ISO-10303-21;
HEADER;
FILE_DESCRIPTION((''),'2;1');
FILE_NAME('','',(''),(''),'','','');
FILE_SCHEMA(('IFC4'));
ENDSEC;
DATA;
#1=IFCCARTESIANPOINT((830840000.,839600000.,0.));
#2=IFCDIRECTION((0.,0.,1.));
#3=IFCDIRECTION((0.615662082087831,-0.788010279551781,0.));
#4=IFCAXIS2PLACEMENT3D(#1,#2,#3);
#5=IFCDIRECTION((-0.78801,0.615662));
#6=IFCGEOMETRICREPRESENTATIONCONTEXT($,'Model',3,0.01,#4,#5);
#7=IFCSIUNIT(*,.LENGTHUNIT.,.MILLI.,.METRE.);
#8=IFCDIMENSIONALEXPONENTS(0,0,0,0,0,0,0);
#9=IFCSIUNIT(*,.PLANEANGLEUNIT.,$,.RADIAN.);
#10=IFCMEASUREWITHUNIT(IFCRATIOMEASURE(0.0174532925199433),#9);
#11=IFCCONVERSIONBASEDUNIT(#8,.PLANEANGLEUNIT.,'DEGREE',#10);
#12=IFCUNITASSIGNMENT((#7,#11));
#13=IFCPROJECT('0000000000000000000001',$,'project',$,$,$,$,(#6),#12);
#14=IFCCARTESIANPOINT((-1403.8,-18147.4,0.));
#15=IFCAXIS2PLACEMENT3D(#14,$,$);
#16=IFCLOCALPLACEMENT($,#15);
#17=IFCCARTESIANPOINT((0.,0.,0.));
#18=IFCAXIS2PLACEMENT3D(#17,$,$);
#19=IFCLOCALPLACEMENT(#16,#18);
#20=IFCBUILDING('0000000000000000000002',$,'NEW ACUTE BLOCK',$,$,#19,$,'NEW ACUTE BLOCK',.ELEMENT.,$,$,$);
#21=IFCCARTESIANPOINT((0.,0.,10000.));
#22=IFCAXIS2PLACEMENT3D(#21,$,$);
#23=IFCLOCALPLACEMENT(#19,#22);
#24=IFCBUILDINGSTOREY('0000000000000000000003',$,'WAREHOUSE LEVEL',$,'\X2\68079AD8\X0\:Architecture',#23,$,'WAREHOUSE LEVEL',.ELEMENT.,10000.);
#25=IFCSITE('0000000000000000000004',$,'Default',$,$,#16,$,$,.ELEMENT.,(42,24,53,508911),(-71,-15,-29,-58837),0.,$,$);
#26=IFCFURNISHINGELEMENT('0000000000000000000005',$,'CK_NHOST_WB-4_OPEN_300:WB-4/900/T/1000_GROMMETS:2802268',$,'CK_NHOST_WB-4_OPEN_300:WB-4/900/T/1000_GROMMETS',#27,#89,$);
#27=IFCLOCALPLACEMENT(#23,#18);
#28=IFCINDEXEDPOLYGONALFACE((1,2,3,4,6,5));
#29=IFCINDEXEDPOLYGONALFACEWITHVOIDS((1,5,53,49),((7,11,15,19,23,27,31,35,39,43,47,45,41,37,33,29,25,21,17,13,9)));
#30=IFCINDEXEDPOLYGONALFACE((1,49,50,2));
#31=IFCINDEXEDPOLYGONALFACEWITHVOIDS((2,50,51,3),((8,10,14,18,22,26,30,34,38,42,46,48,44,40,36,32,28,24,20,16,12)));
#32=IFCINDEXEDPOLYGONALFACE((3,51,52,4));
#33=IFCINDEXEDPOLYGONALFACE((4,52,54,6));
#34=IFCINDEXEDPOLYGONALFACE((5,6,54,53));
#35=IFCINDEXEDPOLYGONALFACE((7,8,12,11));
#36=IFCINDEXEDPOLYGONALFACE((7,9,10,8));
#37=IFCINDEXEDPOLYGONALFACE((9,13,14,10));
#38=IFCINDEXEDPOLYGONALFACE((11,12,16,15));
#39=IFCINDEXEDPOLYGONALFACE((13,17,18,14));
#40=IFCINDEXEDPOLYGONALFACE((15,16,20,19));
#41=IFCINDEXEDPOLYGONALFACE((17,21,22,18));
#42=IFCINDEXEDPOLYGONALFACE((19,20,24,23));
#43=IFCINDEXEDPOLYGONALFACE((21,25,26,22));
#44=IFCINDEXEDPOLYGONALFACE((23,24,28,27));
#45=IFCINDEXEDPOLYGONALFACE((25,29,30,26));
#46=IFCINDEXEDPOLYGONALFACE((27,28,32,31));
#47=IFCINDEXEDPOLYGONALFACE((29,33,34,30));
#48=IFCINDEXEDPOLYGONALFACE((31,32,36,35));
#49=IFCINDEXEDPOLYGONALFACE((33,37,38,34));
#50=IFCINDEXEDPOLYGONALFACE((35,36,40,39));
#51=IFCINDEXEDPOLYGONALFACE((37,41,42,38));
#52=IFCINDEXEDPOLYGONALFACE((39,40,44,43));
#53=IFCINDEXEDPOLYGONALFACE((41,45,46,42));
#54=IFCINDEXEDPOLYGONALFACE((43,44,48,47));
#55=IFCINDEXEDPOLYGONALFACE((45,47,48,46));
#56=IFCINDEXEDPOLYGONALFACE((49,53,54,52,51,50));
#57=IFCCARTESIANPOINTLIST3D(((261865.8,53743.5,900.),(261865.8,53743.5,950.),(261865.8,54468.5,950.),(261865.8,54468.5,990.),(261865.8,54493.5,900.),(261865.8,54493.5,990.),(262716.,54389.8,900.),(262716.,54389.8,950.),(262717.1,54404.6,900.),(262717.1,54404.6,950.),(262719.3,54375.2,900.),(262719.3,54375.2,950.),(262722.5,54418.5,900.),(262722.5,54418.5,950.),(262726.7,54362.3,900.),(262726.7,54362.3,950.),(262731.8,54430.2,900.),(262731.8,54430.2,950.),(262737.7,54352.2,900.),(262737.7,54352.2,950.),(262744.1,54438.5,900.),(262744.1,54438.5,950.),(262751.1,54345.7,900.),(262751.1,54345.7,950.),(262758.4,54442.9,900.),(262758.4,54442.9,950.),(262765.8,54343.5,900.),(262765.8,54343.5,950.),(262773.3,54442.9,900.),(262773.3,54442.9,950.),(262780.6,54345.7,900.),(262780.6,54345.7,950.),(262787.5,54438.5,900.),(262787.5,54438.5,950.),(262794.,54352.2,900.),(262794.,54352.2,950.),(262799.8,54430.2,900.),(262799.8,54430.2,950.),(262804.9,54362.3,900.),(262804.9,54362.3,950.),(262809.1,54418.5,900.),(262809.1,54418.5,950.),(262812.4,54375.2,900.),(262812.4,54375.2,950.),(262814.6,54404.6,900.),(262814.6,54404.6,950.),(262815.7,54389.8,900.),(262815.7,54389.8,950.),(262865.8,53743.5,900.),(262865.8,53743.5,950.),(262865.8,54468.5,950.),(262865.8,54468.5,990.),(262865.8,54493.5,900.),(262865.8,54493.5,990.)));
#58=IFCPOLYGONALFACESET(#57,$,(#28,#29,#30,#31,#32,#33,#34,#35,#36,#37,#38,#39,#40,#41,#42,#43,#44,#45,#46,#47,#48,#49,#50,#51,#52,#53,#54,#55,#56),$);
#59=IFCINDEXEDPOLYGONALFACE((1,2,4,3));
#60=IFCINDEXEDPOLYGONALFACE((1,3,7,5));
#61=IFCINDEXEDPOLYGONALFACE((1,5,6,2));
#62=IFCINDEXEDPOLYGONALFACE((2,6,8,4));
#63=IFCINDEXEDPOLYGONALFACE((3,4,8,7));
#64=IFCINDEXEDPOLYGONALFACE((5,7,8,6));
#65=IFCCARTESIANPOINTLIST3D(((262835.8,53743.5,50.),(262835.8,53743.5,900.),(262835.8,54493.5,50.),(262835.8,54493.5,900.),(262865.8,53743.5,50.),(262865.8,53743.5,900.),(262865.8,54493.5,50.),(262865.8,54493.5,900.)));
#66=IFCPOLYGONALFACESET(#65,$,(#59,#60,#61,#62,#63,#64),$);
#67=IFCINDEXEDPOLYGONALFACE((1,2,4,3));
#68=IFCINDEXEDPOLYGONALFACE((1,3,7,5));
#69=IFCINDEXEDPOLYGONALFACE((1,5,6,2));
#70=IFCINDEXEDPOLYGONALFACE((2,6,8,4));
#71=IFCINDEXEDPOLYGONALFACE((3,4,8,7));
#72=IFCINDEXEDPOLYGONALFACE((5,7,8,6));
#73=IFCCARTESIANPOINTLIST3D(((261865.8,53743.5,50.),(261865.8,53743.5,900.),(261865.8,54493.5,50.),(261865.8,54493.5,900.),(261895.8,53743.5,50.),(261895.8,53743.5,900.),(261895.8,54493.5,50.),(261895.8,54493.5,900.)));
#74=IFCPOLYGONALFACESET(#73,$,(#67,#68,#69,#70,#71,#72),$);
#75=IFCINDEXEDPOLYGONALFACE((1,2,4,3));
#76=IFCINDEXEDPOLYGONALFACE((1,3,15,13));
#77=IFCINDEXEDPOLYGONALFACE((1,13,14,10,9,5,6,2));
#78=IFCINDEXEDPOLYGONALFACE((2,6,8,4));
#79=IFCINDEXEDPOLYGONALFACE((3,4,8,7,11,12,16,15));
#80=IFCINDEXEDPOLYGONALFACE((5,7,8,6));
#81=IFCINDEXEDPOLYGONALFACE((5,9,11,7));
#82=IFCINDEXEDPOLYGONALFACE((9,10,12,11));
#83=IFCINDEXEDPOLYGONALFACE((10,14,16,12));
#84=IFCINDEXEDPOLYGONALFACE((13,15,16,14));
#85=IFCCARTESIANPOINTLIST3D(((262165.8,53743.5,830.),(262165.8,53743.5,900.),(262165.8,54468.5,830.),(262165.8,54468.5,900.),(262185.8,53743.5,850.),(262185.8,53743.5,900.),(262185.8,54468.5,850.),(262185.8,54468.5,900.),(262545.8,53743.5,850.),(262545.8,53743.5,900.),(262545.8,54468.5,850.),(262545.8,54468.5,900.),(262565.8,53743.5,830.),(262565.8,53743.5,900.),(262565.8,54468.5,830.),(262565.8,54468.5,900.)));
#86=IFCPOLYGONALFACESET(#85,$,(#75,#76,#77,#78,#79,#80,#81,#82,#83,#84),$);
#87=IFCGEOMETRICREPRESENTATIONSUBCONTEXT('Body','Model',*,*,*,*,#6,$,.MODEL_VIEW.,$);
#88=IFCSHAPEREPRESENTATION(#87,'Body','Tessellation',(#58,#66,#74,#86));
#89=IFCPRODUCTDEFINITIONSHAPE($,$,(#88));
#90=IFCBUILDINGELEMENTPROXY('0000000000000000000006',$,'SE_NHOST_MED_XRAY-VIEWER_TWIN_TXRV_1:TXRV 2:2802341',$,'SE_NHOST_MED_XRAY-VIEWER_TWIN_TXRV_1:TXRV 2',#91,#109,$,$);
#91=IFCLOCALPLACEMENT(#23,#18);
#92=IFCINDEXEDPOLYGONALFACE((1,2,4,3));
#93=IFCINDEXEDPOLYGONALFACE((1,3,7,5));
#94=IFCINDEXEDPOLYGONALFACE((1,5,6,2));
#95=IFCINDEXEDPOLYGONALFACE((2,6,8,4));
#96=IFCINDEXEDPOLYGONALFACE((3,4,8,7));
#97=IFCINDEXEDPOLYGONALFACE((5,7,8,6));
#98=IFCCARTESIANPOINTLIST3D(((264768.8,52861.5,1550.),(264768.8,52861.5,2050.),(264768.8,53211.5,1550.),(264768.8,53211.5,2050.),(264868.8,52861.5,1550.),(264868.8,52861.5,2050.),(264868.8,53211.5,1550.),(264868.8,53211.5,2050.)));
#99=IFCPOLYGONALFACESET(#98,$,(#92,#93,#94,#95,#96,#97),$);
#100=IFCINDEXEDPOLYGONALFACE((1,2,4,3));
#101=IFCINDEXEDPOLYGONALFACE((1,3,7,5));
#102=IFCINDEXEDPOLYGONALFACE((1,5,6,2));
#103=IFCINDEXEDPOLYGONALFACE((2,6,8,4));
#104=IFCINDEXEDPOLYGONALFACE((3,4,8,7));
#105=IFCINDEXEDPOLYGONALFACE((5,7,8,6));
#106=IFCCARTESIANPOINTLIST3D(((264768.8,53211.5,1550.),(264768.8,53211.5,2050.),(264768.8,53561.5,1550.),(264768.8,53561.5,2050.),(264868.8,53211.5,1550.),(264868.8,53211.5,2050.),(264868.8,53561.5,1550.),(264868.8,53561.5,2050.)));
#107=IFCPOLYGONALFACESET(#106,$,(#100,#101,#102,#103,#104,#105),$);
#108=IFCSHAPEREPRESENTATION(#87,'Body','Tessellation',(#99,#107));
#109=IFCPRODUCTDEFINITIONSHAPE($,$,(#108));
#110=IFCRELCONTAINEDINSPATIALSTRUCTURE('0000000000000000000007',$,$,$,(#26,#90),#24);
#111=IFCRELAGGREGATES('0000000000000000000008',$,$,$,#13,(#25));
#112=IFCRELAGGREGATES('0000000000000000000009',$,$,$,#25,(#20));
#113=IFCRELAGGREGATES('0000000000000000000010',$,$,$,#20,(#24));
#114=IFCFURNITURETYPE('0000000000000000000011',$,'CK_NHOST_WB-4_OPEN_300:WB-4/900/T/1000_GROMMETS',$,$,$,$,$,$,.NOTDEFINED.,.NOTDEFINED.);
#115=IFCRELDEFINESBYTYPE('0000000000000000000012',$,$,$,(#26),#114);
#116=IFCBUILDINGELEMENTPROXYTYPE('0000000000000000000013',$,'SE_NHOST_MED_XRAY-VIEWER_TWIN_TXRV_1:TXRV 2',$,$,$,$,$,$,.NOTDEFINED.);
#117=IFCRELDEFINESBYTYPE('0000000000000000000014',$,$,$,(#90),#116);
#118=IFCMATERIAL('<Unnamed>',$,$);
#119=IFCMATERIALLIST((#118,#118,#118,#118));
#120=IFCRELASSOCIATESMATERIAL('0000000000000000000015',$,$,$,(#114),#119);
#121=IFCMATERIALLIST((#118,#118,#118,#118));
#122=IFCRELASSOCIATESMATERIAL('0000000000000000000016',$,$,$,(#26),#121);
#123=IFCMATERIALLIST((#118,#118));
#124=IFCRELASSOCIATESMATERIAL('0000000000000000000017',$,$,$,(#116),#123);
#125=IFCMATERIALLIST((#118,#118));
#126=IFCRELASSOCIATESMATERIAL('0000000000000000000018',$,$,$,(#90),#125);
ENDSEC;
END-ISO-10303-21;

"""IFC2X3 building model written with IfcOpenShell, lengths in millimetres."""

from ifc_helpers import new_model, entity, si_unit, converted_unit, direction, frame, frame_2d, origin, place, context, subcontext, project, spatial, polyline, rectangle, circle, outline, extrude, source, transform, mapped, material, material_list, type_object, type_shapes, element, save


model = new_model("IFC2X3")

# Units and contexts
model_context = context("Model", 3, precision=0.01, world=frame((830840000.0, 839600000.0, 0.0), z_axis=(0.0, 0.0, 1.0), x_axis=(0.615662082087831, -0.788010279551781, 0.0)), true_north=direction((-0.78801, 0.615662)))
body_context = subcontext(model_context, "Body", "Model", "MODEL_VIEW")
ifc_project = project(units=[si_unit("LENGTHUNIT", "METRE", prefix="MILLI"), converted_unit("PLANEANGLEUNIT", "DEGREE", entity("IfcRatioMeasure", 0.0174532925199433), si_unit("PLANEANGLEUNIT", "RADIAN"), dimensions=[0, 0, 0, 0, 0, 0, 0])], contexts=[model_context])

# Site, building, storey
site_placement = place(None, frame((-1403.8, -18147.4, 0.0)))
site = spatial("IfcSite", under=ifc_project, at=site_placement, Name="Default", CompositionType="ELEMENT", RefLatitude=(42, 24, 53, 508911), RefLongitude=(-71, -15, -29, -58837), RefElevation=0.0)
building_placement = place(site_placement, origin())
building = spatial("IfcBuilding", under=site, at=building_placement, Name="NEW ACUTE BLOCK", LongName="NEW ACUTE BLOCK", CompositionType="ELEMENT")
storey_placement = place(building_placement, frame((0.0, 0.0, 10000.0)))
storey = spatial("IfcBuildingStorey", under=building, at=storey_placement, Name="WAREHOUSE LEVEL", ObjectType="标高:Architecture", LongName="WAREHOUSE LEVEL", CompositionType="ELEMENT", Elevation=10000.0)

# Shared definitions
ifc_material_1 = material(Name="<Unnamed>")

# Furnishing element, opening
ifc_material_list_1 = material_list([ifc_material_1, ifc_material_1, ifc_material_1, ifc_material_1])
ifc_material_list_2 = material_list([ifc_material_1, ifc_material_1, ifc_material_1, ifc_material_1])
furniture_type_1 = type_object("IfcFurnitureType", Name="CK_NHOST_WB-4_OPEN_300:WB-4/900/T/1000_GROMMETS", material=ifc_material_list_2)
shared_shape_1 = source(origin(), body_context, "Body", "SweptSolid", [
    extrude(outline(polyline([(-46.7, -258.3), (43.3, -258.3), (43.3, -233.3), (3.3, -233.3), (3.3, 491.7), (-46.7, 491.7), (-46.7, -258.3)])), frame((-500.0, 116.7, 896.7), z_axis=(1.0, 0.0, 0.0), x_axis=(0.0, 0.0, 1.0)), (0.0, 0.0, 1.0), 1000.0),
    extrude(rectangle(XDim=750.0, YDim=30.0, at=frame_2d((0.0, 0.0), x_axis=(1.0, 0.0))), frame((485.0, 0.0, 0.0), z_axis=(0.0, 0.0, 1.0), x_axis=(0.0, -1.0, 0.0)), (0.0, 0.0, 1.0), 850.0),
    extrude(rectangle(XDim=30.0, YDim=750.0, at=frame_2d((0.0, 0.0), x_axis=(1.0, 0.0))), frame((-485.0, 0.0, 0.0), z_axis=(0.0, 0.0, 1.0), x_axis=(-1.0, 0.0, 0.0)), (0.0, 0.0, 1.0), 850.0),
    extrude(outline(polyline([(-40.0, -200.0), (30.0, -200.0), (30.0, -180.0), (-20.0, -180.0), (-20.0, 180.0), (30.0, 180.0), (30.0, 200.0), (-40.0, 200.0), (-40.0, -200.0)])), frame((0.0, -375.0, 820.0), z_axis=(0.0, 1.0, 0.0), x_axis=(0.0, 0.0, 1.0)), (0.0, 0.0, 1.0), 725.0),
])
type_shapes(furniture_type_1, [shared_shape_1])
furnishing_1_placement = place(storey_placement, frame((262365.8, 54118.5, 50.0)))
furnishing_1 = element("IfcFurnishingElement", 1, at=furnishing_1_placement, inside=storey, type_object=furniture_type_1, material=ifc_material_list_1, Name="CK_NHOST_WB-4_OPEN_300:WB-4/900/T/1000_GROMMETS:2802268", ObjectType="CK_NHOST_WB-4_OPEN_300:WB-4/900/T/1000_GROMMETS", context=body_context, shape_type="MappedRepresentation", body=[
    mapped(shared_shape_1, transform((0.0, 0.0, 0.0), scale=1.0)),
])
opening_1_placement = place(storey_placement, frame((262365.8, 54118.5, 10050.0)))
element("IfcOpeningElement", 2, at=opening_1_placement, cuts=furnishing_1, ObjectType="Opening", context=body_context, shape_type="SweptSolid", body=[
    extrude(circle(Radius=50.0, at=frame_2d((0.0, 0.0), x_axis=(1.0, 0.0))), frame((400.0, 275.0, -9150.0), z_axis=(0.0, 0.0, 1.0), x_axis=(0.0, -1.0, 0.0)), (0.0, 0.0, 1.0), 50.0),
])

# Building element proxy
ifc_material_list_3 = material_list([ifc_material_1, ifc_material_1])
ifc_material_list_4 = material_list([ifc_material_1, ifc_material_1])
building_element_proxy_type_1 = type_object("IfcBuildingElementProxyType", Name="SE_NHOST_MED_XRAY-VIEWER_TWIN_TXRV_1:TXRV 2", PredefinedType="NOTDEFINED", material=ifc_material_list_4)
shared_shape_2 = source(origin(), body_context, "Body", "SweptSolid", [
    extrude(rectangle(XDim=350.0, YDim=100.0, at=frame_2d((0.0, 0.0), x_axis=(1.0, 0.0))), frame((25.0, -50.0, 0.0), z_axis=(0.0, 0.0, 1.0), x_axis=(-1.0, 0.0, 0.0)), (0.0, 0.0, 1.0), 500.0),
    extrude(rectangle(XDim=350.0, YDim=100.0, at=frame_2d((0.0, 0.0), x_axis=(1.0, 0.0))), frame((-325.0, -50.0, 0.0), z_axis=(0.0, 0.0, 1.0), x_axis=(-1.0, 0.0, 0.0)), (0.0, 0.0, 1.0), 500.0),
])
type_shapes(building_element_proxy_type_1, [shared_shape_2])
proxy_1_placement = place(storey_placement, frame((264868.8, 53061.5, 1550.0), z_axis=(0.0, 0.0, 1.0), x_axis=(0.0, -1.0, 0.0)))
element("IfcBuildingElementProxy", 3, at=proxy_1_placement, inside=storey, type_object=building_element_proxy_type_1, material=ifc_material_list_3, Name="SE_NHOST_MED_XRAY-VIEWER_TWIN_TXRV_1:TXRV 2:2802341", ObjectType="SE_NHOST_MED_XRAY-VIEWER_TWIN_TXRV_1:TXRV 2", context=body_context, shape_type="MappedRepresentation", body=[
    mapped(shared_shape_2, transform((0.0, 0.0, 0.0), scale=1.0)),
])

save(model, "model.ifc")
